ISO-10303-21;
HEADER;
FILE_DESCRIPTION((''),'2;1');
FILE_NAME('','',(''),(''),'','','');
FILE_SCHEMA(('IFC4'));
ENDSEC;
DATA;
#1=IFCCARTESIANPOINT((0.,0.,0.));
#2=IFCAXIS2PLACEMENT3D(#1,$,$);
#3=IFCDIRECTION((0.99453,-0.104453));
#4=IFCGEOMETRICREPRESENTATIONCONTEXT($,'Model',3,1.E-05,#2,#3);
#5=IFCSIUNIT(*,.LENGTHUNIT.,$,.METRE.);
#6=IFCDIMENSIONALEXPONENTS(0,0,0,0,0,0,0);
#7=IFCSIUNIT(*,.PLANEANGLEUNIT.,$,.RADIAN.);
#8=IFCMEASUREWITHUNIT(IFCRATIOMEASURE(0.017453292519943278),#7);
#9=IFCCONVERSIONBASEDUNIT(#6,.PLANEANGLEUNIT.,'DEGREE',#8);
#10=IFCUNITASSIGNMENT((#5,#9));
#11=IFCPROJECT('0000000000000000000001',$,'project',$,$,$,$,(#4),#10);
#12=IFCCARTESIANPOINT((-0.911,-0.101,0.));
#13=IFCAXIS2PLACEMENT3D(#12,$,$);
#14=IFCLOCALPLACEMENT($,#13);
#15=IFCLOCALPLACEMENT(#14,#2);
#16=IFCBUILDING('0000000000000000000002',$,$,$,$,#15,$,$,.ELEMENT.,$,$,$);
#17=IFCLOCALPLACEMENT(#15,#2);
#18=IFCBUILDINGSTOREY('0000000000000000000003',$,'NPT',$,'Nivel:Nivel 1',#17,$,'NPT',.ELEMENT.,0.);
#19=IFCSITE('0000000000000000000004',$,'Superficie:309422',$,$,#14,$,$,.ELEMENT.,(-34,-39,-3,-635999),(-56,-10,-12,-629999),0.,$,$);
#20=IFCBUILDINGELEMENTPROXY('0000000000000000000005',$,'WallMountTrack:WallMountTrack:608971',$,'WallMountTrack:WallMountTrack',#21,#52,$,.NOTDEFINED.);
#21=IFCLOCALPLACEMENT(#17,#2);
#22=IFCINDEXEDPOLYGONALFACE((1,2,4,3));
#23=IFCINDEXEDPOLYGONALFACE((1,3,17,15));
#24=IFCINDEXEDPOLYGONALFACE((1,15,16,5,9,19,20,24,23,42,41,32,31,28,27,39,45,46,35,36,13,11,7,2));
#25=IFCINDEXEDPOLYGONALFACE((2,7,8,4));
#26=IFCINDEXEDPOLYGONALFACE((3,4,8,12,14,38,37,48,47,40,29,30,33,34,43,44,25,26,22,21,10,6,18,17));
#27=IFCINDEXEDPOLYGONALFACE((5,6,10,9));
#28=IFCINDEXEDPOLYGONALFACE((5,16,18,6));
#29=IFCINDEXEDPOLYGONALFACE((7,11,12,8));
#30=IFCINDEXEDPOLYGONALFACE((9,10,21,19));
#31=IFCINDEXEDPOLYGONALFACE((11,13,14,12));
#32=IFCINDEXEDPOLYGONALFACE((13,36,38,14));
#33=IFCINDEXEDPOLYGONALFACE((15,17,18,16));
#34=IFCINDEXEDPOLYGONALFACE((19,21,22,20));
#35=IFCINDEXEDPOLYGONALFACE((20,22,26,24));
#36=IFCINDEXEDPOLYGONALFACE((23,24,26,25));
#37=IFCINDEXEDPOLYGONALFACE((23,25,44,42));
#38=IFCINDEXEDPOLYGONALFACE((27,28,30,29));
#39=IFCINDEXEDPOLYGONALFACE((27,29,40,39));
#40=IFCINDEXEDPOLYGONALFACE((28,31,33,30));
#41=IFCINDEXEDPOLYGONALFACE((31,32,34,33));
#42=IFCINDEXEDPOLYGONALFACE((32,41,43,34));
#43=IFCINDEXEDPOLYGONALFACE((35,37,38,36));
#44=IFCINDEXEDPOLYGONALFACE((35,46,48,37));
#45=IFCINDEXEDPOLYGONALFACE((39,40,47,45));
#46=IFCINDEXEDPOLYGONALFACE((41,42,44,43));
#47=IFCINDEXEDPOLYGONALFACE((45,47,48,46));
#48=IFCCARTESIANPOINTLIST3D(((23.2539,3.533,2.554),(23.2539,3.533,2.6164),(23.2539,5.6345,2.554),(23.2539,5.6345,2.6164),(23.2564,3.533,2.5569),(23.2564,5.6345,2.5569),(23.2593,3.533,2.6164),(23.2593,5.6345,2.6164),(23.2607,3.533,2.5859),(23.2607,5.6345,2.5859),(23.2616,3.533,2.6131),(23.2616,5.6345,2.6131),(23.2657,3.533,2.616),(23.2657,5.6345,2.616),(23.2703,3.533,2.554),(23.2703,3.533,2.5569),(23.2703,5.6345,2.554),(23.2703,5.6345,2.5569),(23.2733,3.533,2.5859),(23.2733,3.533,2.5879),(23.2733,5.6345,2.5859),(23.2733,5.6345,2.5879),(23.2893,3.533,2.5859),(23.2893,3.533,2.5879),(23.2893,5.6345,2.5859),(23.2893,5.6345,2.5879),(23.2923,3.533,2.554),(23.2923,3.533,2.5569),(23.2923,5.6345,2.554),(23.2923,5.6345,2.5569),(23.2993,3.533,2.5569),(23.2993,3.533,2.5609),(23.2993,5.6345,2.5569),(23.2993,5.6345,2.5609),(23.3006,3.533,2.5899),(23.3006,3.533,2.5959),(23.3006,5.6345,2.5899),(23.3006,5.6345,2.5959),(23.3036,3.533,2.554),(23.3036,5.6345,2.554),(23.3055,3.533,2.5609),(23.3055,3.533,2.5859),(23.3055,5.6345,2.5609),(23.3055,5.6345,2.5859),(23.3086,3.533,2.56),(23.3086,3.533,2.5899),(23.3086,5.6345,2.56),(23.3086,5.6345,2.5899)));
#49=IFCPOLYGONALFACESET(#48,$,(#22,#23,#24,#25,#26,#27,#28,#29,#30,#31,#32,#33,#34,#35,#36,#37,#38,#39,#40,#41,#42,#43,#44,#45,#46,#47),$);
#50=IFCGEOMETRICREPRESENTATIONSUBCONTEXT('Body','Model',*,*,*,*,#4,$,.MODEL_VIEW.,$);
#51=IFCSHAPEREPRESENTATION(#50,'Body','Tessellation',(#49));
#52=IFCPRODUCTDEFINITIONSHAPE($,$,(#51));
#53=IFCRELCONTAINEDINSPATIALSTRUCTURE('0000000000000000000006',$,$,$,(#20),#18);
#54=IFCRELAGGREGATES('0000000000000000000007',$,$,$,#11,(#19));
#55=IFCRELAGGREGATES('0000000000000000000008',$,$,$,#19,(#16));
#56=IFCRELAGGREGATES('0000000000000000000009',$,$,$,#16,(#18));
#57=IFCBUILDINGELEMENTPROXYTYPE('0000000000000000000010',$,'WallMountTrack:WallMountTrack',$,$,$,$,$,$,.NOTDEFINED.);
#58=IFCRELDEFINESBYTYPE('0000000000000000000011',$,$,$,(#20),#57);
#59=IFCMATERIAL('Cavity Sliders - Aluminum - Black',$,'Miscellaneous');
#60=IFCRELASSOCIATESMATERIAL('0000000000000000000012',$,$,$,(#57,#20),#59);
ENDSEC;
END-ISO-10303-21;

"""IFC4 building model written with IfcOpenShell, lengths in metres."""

from ifc_helpers import new_model, entity, si_unit, converted_unit, direction, frame, origin, place, context, subcontext, project, spatial, polyline, outline, extrude, source, transform, mapped, material, type_object, type_shapes, element, save


model = new_model("IFC4")

# Units and contexts
model_context = context("Model", 3, precision=1e-05, world=origin(), true_north=direction((0.99453, -0.104453)))
body_context = subcontext(model_context, "Body", "Model", "MODEL_VIEW")
ifc_project = project(units=[si_unit("LENGTHUNIT", "METRE"), converted_unit("PLANEANGLEUNIT", "DEGREE", entity("IfcRatioMeasure", 0.017453292519943278), si_unit("PLANEANGLEUNIT", "RADIAN"), dimensions=[0, 0, 0, 0, 0, 0, 0])], contexts=[model_context])

# Site, building, storey
site_placement = place(None, frame((-0.911, -0.101, 0.0)))
site = spatial("IfcSite", under=ifc_project, at=site_placement, Name="Superficie:309422", CompositionType="ELEMENT", RefLatitude=(-34, -39, -3, -635999), RefLongitude=(-56, -10, -12, -629999), RefElevation=0.0)
building_placement = place(site_placement, origin())
building = spatial("IfcBuilding", under=site, at=building_placement, CompositionType="ELEMENT")
storey_placement = place(building_placement, origin())
storey = spatial("IfcBuildingStorey", under=building, at=storey_placement, Name="NPT", ObjectType="Nivel:Nivel 1", LongName="NPT", CompositionType="ELEMENT", Elevation=0.0)

# Building element proxy
ifc_material_1 = material(Name="Cavity Sliders - Aluminum - Black", Category="Miscellaneous")
building_element_proxy_type = type_object("IfcBuildingElementProxyType", Name="WallMountTrack:WallMountTrack", PredefinedType="NOTDEFINED", material=ifc_material_1)
shared_shape_1 = source(origin(), body_context, "Body", "SweptSolid", [
    extrude(outline(polyline([(-0.0115, -0.0255), (0.0184, -0.0255), (0.0244, -0.0205), (0.0244, -0.0093), (0.0215, -0.0093), (0.0215, -0.0162), (0.0175, -0.0162), (0.0175, -0.0224), (-0.0075, -0.0224), (-0.0075, -0.0063), (-0.0095, -0.0063), (-0.0095, 0.0097), (-0.0075, 0.0097), (-0.0075, 0.0223), (0.0215, 0.0267), (0.0215, 0.0127), (0.0244, 0.0127), (0.0244, 0.0291), (-0.038, 0.0291), (-0.038, 0.0237), (-0.0347, 0.0215), (-0.0376, 0.0174), (-0.0175, -0.0175), (-0.0115, -0.0175), (-0.0115, -0.0255)])), frame((-1.0507, -0.0291, 0.0244), z_axis=(1.0, 0.0, 0.0), x_axis=(0.0, 0.0, -1.0)), (0.0, 0.0, 1.0), 2.1015),
])
type_shapes(building_element_proxy_type, [shared_shape_1])
proxy_placement = place(storey_placement, frame((23.2539, 4.5838, 2.554), z_axis=(0.0, 0.0, 1.0), x_axis=(0.0, 1.0, 0.0)))
element("IfcBuildingElementProxy", 1, at=proxy_placement, inside=storey, type_object=building_element_proxy_type, material=ifc_material_1, Name="WallMountTrack:WallMountTrack:608971", ObjectType="WallMountTrack:WallMountTrack", PredefinedType="NOTDEFINED", context=body_context, shape_type="MappedRepresentation", body=[
    mapped(shared_shape_1, transform((0.0, 0.0, 0.0), scale=1.0)),
])

save(model, "model.ifc")
